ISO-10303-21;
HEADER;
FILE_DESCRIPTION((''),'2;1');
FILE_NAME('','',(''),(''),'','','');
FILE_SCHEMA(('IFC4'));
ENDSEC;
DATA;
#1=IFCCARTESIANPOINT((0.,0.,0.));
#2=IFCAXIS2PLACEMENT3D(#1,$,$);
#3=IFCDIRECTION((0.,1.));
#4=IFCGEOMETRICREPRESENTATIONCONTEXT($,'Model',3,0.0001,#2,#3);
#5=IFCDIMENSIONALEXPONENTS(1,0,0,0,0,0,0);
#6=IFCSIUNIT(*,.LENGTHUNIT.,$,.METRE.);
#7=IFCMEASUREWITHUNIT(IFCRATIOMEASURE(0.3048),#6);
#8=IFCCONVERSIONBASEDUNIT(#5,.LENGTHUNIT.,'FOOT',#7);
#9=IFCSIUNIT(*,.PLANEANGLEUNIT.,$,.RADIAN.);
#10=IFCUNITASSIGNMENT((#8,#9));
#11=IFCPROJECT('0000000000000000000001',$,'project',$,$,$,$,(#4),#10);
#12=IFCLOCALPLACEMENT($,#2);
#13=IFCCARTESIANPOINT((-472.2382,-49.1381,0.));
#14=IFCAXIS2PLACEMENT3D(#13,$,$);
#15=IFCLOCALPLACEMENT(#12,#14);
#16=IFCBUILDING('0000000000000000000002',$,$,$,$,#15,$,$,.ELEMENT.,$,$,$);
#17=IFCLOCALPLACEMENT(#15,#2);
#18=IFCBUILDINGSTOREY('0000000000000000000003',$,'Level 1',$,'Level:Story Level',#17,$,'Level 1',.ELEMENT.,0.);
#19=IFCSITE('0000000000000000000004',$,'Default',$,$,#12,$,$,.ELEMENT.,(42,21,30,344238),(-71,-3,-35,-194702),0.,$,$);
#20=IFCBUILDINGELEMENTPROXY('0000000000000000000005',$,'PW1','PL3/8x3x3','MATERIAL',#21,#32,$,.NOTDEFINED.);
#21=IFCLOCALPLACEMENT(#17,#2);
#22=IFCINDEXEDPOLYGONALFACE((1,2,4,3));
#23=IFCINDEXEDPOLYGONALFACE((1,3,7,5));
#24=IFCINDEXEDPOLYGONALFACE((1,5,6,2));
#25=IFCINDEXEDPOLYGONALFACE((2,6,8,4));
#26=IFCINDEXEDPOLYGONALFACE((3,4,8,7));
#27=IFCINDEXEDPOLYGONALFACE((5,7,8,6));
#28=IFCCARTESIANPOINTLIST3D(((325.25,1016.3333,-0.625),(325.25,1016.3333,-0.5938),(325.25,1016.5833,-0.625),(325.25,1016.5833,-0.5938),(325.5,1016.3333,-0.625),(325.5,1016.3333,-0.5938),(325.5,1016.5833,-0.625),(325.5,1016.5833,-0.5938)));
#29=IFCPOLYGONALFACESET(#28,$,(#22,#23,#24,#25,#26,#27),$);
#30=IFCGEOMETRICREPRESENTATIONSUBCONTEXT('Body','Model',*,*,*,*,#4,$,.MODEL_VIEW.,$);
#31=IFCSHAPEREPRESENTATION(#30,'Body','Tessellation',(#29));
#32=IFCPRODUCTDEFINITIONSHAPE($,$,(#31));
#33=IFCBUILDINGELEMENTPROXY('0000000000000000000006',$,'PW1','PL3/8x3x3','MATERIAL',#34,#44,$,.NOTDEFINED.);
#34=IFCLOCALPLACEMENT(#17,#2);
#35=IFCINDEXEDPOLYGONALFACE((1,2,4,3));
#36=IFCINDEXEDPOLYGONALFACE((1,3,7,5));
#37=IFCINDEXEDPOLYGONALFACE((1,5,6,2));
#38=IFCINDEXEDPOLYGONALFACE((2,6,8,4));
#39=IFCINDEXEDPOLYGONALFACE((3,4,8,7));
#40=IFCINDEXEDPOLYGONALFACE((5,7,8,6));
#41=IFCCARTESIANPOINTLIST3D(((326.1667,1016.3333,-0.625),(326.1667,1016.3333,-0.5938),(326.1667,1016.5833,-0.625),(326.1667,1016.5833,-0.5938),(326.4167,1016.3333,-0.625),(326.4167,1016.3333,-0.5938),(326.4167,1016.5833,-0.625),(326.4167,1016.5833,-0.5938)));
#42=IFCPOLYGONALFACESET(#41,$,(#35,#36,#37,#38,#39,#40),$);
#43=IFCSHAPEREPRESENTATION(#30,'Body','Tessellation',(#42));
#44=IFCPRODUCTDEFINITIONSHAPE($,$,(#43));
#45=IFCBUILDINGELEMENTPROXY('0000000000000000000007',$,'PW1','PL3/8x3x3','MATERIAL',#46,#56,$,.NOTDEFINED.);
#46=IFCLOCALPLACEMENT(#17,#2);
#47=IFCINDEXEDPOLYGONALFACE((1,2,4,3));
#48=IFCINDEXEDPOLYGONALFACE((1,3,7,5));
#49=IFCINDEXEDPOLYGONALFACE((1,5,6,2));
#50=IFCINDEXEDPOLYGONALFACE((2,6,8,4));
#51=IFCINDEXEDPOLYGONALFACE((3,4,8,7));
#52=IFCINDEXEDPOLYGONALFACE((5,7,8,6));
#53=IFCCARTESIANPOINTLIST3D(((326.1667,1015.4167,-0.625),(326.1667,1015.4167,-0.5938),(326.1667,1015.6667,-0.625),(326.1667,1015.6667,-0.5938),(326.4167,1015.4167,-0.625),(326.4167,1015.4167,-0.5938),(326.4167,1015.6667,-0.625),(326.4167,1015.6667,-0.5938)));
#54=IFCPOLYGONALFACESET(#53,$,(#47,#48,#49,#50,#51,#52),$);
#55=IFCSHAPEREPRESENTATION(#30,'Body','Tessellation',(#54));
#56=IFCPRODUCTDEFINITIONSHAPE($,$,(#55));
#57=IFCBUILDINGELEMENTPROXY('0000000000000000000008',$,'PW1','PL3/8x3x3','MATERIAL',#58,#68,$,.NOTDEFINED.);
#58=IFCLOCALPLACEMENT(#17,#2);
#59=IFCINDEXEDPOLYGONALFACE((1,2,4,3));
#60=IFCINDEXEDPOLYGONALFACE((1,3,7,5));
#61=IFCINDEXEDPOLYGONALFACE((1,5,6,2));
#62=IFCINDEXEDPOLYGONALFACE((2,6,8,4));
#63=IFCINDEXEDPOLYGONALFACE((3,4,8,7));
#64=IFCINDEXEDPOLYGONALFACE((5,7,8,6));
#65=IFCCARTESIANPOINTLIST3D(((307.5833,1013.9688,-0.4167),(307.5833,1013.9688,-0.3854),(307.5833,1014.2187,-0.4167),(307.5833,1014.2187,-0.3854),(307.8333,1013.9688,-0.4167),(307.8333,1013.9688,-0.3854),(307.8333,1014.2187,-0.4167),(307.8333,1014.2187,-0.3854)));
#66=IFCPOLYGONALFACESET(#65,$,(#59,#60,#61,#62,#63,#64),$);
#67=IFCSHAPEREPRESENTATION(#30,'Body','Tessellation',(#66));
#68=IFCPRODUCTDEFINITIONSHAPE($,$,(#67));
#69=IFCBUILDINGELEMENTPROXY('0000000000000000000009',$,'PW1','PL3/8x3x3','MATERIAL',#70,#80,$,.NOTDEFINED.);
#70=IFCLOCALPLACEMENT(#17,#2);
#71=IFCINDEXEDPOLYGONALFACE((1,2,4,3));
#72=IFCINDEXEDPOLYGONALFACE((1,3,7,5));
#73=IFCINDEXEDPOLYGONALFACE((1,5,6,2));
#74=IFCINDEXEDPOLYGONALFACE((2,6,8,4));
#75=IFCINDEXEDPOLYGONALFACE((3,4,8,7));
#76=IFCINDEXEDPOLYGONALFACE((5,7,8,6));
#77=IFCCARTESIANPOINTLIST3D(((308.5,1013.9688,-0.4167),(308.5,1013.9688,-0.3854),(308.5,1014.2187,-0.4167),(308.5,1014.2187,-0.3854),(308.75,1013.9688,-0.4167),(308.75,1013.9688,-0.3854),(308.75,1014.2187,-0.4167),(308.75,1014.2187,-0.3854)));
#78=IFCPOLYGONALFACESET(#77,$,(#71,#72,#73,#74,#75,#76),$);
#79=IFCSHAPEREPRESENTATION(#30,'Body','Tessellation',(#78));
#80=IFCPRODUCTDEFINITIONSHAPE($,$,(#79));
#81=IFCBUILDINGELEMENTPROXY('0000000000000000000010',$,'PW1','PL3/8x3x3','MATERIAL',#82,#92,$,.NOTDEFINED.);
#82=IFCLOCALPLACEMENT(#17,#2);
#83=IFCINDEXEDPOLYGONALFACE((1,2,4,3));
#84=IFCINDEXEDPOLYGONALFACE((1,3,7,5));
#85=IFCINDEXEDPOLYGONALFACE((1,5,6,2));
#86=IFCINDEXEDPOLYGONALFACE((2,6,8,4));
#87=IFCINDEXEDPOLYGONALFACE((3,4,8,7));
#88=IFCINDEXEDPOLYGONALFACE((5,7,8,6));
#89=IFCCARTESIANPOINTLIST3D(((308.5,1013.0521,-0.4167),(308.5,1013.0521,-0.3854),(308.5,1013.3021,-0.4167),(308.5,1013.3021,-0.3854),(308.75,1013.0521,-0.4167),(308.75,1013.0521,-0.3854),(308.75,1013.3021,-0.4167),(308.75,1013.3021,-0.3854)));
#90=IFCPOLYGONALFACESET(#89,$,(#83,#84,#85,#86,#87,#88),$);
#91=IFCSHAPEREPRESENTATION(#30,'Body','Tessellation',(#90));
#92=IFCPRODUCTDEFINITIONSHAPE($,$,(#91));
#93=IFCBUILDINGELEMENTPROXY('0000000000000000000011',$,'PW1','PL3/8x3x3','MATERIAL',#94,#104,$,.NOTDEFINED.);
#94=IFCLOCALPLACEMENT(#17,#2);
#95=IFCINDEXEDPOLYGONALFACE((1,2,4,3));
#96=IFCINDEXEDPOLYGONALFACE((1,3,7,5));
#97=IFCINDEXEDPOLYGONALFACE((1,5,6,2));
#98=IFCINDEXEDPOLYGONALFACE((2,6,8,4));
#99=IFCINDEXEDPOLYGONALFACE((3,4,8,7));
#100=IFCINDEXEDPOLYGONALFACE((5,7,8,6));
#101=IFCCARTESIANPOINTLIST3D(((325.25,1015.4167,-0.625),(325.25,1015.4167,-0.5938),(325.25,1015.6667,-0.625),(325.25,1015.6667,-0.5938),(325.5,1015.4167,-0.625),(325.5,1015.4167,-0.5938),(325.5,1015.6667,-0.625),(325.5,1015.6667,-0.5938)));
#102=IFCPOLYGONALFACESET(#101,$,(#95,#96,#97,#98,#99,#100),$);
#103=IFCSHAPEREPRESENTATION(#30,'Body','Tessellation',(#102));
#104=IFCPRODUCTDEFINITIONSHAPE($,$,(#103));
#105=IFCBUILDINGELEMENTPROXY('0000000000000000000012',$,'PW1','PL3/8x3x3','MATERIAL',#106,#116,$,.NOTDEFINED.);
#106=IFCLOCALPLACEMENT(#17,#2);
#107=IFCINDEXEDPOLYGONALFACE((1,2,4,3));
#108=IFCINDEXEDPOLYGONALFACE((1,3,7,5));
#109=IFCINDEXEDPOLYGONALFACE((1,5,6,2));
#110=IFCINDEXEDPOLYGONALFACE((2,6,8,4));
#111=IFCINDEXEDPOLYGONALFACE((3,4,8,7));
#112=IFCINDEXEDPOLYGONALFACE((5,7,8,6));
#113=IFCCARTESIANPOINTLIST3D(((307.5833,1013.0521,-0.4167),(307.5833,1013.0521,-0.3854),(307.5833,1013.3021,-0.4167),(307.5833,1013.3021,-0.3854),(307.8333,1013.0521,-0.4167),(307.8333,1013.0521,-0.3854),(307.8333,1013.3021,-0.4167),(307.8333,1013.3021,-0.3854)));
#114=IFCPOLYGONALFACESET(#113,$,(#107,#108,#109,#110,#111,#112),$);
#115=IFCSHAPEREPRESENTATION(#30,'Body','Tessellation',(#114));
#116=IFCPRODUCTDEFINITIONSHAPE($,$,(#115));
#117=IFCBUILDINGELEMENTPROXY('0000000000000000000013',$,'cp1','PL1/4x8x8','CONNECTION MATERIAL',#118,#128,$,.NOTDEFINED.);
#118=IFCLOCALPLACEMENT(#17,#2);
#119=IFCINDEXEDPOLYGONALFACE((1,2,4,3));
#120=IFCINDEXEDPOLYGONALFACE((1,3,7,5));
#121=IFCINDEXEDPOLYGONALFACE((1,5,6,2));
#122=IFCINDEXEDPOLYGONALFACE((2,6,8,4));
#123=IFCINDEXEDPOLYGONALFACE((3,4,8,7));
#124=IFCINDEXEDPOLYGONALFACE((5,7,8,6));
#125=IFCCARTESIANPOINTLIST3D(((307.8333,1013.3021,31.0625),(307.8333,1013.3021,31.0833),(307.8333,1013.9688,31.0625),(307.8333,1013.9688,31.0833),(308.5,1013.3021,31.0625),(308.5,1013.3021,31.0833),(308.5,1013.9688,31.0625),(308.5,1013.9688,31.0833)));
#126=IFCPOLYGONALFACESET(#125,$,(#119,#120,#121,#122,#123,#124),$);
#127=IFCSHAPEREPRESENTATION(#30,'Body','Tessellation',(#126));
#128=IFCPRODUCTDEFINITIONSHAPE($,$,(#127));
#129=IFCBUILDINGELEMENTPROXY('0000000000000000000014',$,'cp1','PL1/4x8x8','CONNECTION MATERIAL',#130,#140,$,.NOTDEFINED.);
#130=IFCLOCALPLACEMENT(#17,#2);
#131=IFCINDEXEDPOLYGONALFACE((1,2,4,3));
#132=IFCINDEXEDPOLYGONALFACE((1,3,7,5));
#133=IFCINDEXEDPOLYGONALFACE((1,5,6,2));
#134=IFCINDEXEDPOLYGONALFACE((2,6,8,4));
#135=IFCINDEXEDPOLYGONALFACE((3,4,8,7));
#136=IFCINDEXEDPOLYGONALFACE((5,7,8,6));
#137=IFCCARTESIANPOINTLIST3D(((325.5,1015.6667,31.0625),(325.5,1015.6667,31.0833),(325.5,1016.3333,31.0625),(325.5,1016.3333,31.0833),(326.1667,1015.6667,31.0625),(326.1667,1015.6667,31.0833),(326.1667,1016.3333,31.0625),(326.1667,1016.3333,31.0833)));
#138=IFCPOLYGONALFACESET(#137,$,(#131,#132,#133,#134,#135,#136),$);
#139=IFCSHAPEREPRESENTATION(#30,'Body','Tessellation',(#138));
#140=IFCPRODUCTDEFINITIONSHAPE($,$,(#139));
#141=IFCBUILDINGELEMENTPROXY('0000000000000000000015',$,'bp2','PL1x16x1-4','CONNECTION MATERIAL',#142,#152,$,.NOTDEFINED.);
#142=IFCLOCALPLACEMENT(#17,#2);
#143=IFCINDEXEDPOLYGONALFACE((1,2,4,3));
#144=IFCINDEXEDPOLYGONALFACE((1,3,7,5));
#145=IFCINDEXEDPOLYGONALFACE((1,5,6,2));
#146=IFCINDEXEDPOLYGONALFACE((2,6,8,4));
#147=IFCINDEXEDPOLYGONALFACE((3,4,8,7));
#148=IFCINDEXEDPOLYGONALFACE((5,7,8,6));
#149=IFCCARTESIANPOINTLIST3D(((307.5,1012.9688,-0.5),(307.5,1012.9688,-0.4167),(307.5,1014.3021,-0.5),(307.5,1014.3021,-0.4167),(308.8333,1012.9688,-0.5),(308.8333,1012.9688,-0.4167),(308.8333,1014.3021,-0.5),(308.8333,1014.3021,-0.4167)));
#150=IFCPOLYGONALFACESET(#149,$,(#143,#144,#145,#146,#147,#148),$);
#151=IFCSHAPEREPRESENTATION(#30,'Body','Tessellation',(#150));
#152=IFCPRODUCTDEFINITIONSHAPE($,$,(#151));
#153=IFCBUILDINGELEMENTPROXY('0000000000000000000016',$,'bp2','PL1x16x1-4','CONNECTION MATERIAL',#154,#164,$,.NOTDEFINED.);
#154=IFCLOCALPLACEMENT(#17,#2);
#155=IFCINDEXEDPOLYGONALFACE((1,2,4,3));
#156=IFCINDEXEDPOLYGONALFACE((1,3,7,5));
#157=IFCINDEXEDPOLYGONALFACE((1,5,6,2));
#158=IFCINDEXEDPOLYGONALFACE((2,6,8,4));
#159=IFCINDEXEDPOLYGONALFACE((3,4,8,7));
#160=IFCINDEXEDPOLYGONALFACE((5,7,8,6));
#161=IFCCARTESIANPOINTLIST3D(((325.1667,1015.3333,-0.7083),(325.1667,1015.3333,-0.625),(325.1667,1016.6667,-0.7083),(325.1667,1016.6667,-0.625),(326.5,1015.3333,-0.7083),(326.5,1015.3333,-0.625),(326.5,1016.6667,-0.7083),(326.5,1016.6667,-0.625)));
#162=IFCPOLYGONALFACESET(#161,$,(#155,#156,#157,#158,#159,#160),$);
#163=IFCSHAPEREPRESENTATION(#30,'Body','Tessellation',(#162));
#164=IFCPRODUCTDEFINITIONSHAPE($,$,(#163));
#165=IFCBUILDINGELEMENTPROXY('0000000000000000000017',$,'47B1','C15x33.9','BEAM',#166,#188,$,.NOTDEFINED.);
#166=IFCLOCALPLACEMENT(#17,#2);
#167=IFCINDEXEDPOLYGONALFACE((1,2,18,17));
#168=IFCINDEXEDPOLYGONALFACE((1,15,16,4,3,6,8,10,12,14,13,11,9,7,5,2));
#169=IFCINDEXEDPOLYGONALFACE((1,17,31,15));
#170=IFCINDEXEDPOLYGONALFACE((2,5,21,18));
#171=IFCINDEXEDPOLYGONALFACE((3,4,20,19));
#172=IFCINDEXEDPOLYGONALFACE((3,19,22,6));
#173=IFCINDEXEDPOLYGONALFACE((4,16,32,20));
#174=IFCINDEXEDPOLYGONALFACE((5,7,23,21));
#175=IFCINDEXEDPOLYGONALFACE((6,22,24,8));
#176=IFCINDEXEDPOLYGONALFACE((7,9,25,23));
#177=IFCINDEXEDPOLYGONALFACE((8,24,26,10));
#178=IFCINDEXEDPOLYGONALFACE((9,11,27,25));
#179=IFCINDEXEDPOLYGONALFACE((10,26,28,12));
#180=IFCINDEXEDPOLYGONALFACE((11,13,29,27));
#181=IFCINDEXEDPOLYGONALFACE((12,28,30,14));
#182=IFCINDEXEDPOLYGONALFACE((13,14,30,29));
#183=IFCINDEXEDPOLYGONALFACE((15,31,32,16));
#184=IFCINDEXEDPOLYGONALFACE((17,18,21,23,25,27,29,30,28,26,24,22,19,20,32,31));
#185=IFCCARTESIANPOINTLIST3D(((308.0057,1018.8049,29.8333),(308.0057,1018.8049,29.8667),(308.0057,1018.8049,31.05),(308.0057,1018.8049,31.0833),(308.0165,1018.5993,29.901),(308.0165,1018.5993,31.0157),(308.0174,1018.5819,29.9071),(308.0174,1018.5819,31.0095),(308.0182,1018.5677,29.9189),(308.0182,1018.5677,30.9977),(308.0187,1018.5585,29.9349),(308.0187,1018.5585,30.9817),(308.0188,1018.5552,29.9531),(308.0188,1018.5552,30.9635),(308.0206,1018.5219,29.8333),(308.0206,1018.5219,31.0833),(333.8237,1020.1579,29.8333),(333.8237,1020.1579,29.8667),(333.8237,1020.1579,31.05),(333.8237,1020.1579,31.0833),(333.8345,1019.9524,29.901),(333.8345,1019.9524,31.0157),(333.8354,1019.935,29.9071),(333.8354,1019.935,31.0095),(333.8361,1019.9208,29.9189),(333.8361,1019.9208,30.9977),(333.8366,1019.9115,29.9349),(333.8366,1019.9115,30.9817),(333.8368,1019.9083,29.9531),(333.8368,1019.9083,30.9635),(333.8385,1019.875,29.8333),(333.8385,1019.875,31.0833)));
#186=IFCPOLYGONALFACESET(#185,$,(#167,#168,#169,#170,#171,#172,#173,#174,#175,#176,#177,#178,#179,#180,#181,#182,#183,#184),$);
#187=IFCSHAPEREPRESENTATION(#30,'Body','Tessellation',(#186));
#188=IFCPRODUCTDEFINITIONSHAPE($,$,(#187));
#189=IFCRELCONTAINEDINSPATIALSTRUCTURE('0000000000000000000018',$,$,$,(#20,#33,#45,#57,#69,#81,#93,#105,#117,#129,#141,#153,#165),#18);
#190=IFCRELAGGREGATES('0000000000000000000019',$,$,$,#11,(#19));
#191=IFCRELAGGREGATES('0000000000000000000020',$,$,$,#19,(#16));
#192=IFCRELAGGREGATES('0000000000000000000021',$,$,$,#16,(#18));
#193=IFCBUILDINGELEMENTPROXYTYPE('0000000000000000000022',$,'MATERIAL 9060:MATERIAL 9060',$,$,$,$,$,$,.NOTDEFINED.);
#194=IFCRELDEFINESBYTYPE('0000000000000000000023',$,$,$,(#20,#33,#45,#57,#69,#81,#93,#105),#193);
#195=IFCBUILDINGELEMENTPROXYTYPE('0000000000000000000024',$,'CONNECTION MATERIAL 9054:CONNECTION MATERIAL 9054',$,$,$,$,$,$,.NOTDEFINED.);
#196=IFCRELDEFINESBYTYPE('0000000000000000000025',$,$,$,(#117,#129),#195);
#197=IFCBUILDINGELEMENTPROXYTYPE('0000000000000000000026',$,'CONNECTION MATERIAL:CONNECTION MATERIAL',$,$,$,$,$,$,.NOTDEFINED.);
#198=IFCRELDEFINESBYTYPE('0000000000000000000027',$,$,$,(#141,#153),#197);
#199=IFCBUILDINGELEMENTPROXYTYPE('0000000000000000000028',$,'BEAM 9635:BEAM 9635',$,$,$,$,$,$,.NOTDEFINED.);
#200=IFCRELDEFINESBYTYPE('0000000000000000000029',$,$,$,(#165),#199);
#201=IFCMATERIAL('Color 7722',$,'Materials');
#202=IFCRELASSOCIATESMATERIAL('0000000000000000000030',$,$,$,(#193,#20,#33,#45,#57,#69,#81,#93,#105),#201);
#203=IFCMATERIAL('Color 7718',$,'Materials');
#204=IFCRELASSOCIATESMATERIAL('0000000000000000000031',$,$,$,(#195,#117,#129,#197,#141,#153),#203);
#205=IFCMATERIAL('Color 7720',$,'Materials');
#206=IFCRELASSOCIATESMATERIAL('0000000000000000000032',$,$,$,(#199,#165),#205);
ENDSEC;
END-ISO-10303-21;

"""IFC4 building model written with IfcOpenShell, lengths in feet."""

from ifc_helpers import new_model, entity, si_unit, converted_unit, direction, frame, origin, origin_2d_with_axis, place, context, subcontext, project, spatial, polyline, rectangle, outline, extrude, source, transform, mapped, material, type_object, type_shapes, element, save


model = new_model("IFC4")

# Units and contexts
model_context = context("Model", 3, precision=0.0001, world=origin(), true_north=direction((0.0, 1.0)))
body_context = subcontext(model_context, "Body", "Model", "MODEL_VIEW")
ifc_project = project(units=[converted_unit("LENGTHUNIT", "FOOT", entity("IfcRatioMeasure", 0.3048), si_unit("LENGTHUNIT", "METRE"), dimensions=[1, 0, 0, 0, 0, 0, 0]), si_unit("PLANEANGLEUNIT", "RADIAN")], contexts=[model_context])

# Site, building, storey
site_placement = place(None, origin())
site = spatial("IfcSite", under=ifc_project, at=site_placement, Name="Default", CompositionType="ELEMENT", RefLatitude=(42, 21, 30, 344238), RefLongitude=(-71, -3, -35, -194702), RefElevation=0.0)
building_placement = place(site_placement, frame((-472.2382, -49.1381, 0.0)))
building = spatial("IfcBuilding", under=site, at=building_placement, CompositionType="ELEMENT")
storey_placement = place(building_placement, origin())
storey = spatial("IfcBuildingStorey", under=building, at=storey_placement, Name="Level 1", ObjectType="Level:Story Level", LongName="Level 1", CompositionType="ELEMENT", Elevation=0.0)

# Building element proxies
ifc_material_1 = material(Name="Color 7722", Category="Materials")
building_element_proxy_type_1 = type_object("IfcBuildingElementProxyType", Name="MATERIAL 9060:MATERIAL 9060", PredefinedType="NOTDEFINED", material=ifc_material_1)
shared_shape_1 = source(origin(), body_context, "Body", "SweptSolid", [
    extrude(rectangle(XDim=0.25, YDim=0.25, at=origin_2d_with_axis()), frame((0.125, -0.125, 0.0)), (0.0, 0.0, 1.0), 0.0312),
])
type_shapes(building_element_proxy_type_1, [shared_shape_1])
for number, where, z_axis, x_axis, name in (
    (1, (325.25, 1016.5833, -0.5938), (0.0, 0.0, -1.0), (0.0, -1.0, 0.0), "PW1"),
    (2, (326.1667, 1016.5833, -0.5938), (0.0, 0.0, -1.0), (0.0, -1.0, 0.0), "PW1"),
    (3, (326.1667, 1015.6667, -0.5938), (0.0, 0.0, -1.0), (0.0, -1.0, 0.0), "PW1"),
    (4, (307.5833, 1014.2188, -0.3854), (0.0, 0.0, -1.0), (0.0, -1.0, 0.0), "PW1"),
    (5, (308.5, 1014.2188, -0.3854), (0.0, 0.0, -1.0), (0.0, -1.0, 0.0), "PW1"),
    (6, (308.5, 1013.3021, -0.3854), (0.0, 0.0, -1.0), (0.0, -1.0, 0.0), "PW1"),
    (7, (325.25, 1015.6667, -0.5938), (0.0, 0.0, -1.0), (0.0, -1.0, 0.0), "PW1"),
    (8, (307.5833, 1013.3021, -0.3854), (0.0, 0.0, -1.0), (0.0, -1.0, 0.0), "PW1"),
):
    element("IfcBuildingElementProxy", number, at=place(building_placement, frame(where, z_axis=z_axis, x_axis=x_axis)), inside=storey, type_object=building_element_proxy_type_1, material=ifc_material_1, Name=name, Description="PL3/8x3x3", ObjectType="MATERIAL", PredefinedType="NOTDEFINED", context=body_context, shape_type="MappedRepresentation", body=[
        mapped(shared_shape_1, transform((0.0, 0.0, 0.0), scale=1.0)),
    ])
ifc_material_2 = material(Name="Color 7718", Category="Materials")
building_element_proxy_type_2 = type_object("IfcBuildingElementProxyType", Name="CONNECTION MATERIAL 9054:CONNECTION MATERIAL 9054", PredefinedType="NOTDEFINED", material=ifc_material_2)
shared_shape_2 = source(origin(), body_context, "Body", "SweptSolid", [
    extrude(rectangle(XDim=0.6667, YDim=0.6667, at=origin_2d_with_axis()), frame((0.0, 0.0, -0.0208)), (0.0, 0.0, 1.0), 0.0208),
])
type_shapes(building_element_proxy_type_2, [shared_shape_2])
for number, where, z_axis, x_axis, name in (
    (9, (308.1667, 1013.6354, 31.0625), (0.0, 0.0, -1.0), (1.0, 0.0, 0.0), "cp1"),
    (10, (325.8333, 1016.0, 31.0625), (0.0, 0.0, -1.0), (1.0, 0.0, 0.0), "cp1"),
):
    element("IfcBuildingElementProxy", number, at=place(building_placement, frame(where, z_axis=z_axis, x_axis=x_axis)), inside=storey, type_object=building_element_proxy_type_2, material=ifc_material_2, Name=name, Description="PL1/4x8x8", ObjectType="CONNECTION MATERIAL", PredefinedType="NOTDEFINED", context=body_context, shape_type="MappedRepresentation", body=[
        mapped(shared_shape_2, transform((0.0, 0.0, 0.0), scale=1.0)),
    ])
building_element_proxy_type_3 = type_object("IfcBuildingElementProxyType", Name="CONNECTION MATERIAL:CONNECTION MATERIAL", PredefinedType="NOTDEFINED", material=ifc_material_2)
shared_shape_3 = source(origin(), body_context, "Body", "SweptSolid", [
    extrude(rectangle(XDim=1.3333, YDim=1.3333, at=origin_2d_with_axis()), frame((0.0, 0.0, -0.0833)), (0.0, 0.0, 1.0), 0.0833),
])
type_shapes(building_element_proxy_type_3, [shared_shape_3])
for number, where, name in (
    (11, (308.1667, 1013.6354, -0.4167), "bp2"),
    (12, (325.8333, 1016.0, -0.625), "bp2"),
):
    element("IfcBuildingElementProxy", number, at=place(building_placement, frame(where)), inside=storey, type_object=building_element_proxy_type_3, material=ifc_material_2, Name=name, Description="PL1x16x1-4", ObjectType="CONNECTION MATERIAL", PredefinedType="NOTDEFINED", context=body_context, shape_type="MappedRepresentation", body=[
        mapped(shared_shape_3, transform((0.0, 0.0, 0.0), scale=1.0)),
    ])
ifc_material_3 = material(Name="Color 7720", Category="Materials")
building_element_proxy_type_4 = type_object("IfcBuildingElementProxyType", Name="BEAM 9635:BEAM 9635", PredefinedType="NOTDEFINED", material=ifc_material_3)
shared_shape_4 = source(origin(), body_context, "Body", "SweptSolid", [
    extrude(outline(polyline([(-0.625, -0.1025), (0.625, -0.1025), (0.625, 0.1808), (0.5917, 0.1808), (0.5574, -0.025), (0.5512, -0.0424), (0.5394, -0.0566), (0.5234, -0.0659), (0.5052, -0.0692), (-0.5052, -0.0692), (-0.5234, -0.0659), (-0.5394, -0.0566), (-0.5512, -0.0424), (-0.5574, -0.025), (-0.5917, 0.1808), (-0.625, 0.1808), (-0.625, -0.1025)])), frame((0.0, 0.625, 0.1808), z_axis=(1.0, 0.0, 0.0), x_axis=(0.0, -1.0, 0.0)), (0.0, 0.0, 1.0), 25.8534),
])
type_shapes(building_element_proxy_type_4, [shared_shape_4])
proxy_placement = place(building_placement, frame((308.0057, 1018.8049, 29.8333), z_axis=(0.052336, -0.99863, 0.0), x_axis=(0.99863, 0.052336, 0.0)))
element("IfcBuildingElementProxy", 13, at=proxy_placement, inside=storey, type_object=building_element_proxy_type_4, material=ifc_material_3, Name="47B1", Description="C15x33.9", ObjectType="BEAM", PredefinedType="NOTDEFINED", context=body_context, shape_type="MappedRepresentation", body=[
    mapped(shared_shape_4, transform((0.0, 0.0, 0.0), scale=1.0)),
])

save(model, "model.ifc")
